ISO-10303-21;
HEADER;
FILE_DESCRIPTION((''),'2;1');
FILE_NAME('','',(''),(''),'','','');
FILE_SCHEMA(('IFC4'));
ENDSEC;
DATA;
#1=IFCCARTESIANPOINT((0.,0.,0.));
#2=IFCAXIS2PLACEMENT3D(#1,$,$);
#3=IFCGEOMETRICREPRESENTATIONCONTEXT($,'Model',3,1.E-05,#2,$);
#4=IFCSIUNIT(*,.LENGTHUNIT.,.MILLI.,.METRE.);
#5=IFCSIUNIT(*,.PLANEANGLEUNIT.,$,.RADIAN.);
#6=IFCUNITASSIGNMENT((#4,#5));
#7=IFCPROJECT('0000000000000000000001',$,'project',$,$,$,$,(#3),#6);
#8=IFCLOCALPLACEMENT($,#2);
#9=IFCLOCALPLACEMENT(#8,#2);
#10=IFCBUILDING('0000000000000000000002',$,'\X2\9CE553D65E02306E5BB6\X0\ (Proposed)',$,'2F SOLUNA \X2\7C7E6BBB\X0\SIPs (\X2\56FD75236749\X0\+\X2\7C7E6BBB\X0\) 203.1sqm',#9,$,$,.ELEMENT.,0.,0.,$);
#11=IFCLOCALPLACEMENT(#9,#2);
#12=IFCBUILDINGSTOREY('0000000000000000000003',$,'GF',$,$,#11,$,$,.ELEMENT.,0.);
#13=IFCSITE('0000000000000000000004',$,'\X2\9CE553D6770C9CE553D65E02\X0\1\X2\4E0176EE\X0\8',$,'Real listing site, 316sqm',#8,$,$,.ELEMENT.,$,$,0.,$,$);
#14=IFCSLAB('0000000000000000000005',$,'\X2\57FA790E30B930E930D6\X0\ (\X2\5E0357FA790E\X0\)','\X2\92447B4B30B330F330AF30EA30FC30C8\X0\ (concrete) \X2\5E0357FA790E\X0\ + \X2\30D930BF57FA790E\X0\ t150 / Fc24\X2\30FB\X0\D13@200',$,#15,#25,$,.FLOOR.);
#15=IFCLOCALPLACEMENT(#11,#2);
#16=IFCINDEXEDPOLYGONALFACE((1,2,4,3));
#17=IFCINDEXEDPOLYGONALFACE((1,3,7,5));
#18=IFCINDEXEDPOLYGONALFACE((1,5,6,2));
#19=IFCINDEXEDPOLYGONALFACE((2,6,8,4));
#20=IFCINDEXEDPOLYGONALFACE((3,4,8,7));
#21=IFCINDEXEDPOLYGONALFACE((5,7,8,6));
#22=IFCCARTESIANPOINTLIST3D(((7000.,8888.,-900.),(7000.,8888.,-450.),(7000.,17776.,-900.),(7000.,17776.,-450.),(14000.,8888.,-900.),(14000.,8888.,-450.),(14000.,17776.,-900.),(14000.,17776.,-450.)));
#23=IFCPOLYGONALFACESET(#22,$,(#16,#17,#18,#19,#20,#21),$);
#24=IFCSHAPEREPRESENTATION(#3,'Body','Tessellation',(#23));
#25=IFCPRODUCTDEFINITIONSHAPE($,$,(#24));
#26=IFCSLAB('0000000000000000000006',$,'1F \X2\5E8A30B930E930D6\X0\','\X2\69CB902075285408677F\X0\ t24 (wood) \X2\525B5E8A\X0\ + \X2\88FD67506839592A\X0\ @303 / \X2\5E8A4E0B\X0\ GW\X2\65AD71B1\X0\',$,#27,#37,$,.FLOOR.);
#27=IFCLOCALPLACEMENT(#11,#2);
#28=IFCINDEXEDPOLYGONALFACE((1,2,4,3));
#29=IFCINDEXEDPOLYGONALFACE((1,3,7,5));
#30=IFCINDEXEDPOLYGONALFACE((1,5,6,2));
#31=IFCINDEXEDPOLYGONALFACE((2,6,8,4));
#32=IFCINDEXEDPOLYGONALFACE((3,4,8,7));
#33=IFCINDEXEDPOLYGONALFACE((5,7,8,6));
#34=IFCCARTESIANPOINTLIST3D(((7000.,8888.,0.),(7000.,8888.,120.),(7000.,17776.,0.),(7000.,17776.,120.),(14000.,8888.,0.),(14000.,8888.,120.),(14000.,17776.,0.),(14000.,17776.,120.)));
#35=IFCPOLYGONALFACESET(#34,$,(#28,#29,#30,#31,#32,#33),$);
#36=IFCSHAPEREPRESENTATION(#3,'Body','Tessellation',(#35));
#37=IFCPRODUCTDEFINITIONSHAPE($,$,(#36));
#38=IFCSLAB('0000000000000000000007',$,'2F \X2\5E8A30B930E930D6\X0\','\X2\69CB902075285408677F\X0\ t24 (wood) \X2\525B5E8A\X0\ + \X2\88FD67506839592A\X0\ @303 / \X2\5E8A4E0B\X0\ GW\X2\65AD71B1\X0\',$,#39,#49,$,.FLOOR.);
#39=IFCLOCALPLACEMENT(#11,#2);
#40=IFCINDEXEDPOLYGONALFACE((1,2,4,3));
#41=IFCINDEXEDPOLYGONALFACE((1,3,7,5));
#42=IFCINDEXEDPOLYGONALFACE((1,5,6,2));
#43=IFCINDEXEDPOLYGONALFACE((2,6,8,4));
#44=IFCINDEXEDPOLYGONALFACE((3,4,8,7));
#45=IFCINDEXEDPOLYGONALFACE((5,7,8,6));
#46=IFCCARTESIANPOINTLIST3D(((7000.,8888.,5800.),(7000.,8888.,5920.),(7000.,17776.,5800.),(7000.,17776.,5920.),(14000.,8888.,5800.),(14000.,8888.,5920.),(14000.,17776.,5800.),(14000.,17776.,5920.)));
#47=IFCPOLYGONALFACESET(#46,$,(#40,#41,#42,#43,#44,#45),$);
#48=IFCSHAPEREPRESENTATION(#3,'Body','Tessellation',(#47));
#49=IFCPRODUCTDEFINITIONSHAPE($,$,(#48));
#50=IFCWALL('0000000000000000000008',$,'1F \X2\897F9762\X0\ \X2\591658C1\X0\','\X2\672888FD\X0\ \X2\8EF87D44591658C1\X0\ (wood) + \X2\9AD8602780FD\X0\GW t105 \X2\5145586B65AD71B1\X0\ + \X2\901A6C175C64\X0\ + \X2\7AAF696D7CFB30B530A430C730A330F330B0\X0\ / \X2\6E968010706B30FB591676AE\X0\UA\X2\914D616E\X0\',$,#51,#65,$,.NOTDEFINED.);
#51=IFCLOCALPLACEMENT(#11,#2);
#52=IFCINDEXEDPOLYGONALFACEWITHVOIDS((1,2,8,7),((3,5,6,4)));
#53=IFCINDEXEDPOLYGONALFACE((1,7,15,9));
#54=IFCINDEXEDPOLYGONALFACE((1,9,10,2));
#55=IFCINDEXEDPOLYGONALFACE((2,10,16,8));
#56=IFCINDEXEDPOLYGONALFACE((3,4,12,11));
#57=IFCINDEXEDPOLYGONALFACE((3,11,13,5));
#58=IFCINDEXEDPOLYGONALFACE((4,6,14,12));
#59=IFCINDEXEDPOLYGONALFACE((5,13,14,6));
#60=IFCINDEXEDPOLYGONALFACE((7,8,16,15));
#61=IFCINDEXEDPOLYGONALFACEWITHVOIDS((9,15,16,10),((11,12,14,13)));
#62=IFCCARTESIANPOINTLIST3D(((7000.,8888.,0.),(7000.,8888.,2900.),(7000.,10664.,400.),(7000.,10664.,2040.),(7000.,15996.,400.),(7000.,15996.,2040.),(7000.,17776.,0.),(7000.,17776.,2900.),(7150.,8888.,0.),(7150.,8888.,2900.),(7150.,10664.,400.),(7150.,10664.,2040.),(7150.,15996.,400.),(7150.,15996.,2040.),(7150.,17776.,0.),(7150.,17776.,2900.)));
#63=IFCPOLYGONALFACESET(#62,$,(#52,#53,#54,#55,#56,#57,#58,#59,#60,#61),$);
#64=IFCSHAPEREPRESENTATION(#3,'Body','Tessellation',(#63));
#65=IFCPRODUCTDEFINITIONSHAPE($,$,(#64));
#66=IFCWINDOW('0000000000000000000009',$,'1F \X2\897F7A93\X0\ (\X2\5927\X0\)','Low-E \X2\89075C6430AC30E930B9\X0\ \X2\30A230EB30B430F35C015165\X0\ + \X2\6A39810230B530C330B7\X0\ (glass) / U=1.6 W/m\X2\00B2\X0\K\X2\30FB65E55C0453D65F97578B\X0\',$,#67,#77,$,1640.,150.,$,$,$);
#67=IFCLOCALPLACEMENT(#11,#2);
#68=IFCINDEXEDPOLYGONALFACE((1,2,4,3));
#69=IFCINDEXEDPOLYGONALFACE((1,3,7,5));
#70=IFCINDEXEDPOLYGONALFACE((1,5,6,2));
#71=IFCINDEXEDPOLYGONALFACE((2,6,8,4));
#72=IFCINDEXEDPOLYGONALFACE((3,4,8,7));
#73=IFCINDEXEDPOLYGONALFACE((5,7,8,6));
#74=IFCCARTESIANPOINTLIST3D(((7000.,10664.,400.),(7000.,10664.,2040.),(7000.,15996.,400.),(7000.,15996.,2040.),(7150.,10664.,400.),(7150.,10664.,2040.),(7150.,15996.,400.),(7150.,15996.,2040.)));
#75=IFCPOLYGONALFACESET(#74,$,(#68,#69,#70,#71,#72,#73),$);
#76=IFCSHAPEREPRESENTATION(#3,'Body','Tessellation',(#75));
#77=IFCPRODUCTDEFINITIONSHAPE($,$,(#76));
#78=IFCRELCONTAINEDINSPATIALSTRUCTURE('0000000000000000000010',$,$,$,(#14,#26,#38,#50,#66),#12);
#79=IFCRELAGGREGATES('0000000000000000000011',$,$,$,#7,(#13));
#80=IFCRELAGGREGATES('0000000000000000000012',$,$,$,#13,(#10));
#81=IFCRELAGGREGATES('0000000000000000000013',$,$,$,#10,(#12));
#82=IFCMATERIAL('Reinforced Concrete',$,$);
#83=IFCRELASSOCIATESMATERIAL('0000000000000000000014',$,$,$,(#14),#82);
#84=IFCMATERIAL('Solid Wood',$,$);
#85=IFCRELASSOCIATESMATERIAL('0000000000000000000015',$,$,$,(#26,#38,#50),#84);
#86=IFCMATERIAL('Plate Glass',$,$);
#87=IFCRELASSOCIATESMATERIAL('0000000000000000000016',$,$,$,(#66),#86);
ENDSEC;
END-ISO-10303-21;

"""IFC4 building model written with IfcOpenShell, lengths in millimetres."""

from ifc_helpers import new_model, si_unit, frame, frame_2d, origin, place, context, project, spatial, rectangle, extrude, material, element, fill, save


model = new_model("IFC4")

# Units and contexts
model_context = context("Model", 3, precision=1e-05, world=origin())
ifc_project = project(units=[si_unit("LENGTHUNIT", "METRE", prefix="MILLI"), si_unit("PLANEANGLEUNIT", "RADIAN")], contexts=[model_context])

# Site, building, storey
site_placement = place(None, origin())
site = spatial("IfcSite", under=ifc_project, at=site_placement, Name="鳥取県鳥取市1丁目8", ObjectType="Real listing site, 316sqm", CompositionType="ELEMENT", RefElevation=0.0)
building_placement = place(site_placement, origin())
building = spatial("IfcBuilding", under=site, at=building_placement, Name="鳥取市の家 (Proposed)", ObjectType="2F SOLUNA 籾殻SIPs (国産杉+籾殻) 203.1sqm", CompositionType="ELEMENT", ElevationOfRefHeight=0.0, ElevationOfTerrain=0.0)
storey_placement = place(building_placement, origin())
storey = spatial("IfcBuildingStorey", under=building, at=storey_placement, Name="GF", CompositionType="ELEMENT", Elevation=0.0)

# Slabs
ifc_material_1 = material(Name="Reinforced Concrete")
slab_1_placement = place(storey_placement, frame((3500.0, 4444.0, -450.0)))
element("IfcSlab", 1, at=slab_1_placement, inside=storey, material=ifc_material_1, Name="基礎スラブ (布基礎)", Description="鉄筋コンクリート (concrete) 布基礎 + ベタ基礎 t150 / Fc24・D13@200", PredefinedType="FLOOR", context=model_context, shape_type="SweptSolid", body=[
    extrude(rectangle(XDim=7000.0, YDim=8888.0, at=frame_2d((3500.0, 4444.0))), frame((3500.0, 4444.0, -450.0)), (0.0, 0.0, 1.0), 450.0),
])
ifc_material_2 = material(Name="Solid Wood")
slab_2_placement = place(storey_placement, frame((3500.0, 4444.0, 0.0)))
element("IfcSlab", 2, at=slab_2_placement, inside=storey, material=ifc_material_2, Name="1F 床スラブ", Description="構造用合板 t24 (wood) 剛床 + 製材根太 @303 / 床下 GW断熱", PredefinedType="FLOOR", context=model_context, shape_type="SweptSolid", body=[
    extrude(rectangle(XDim=7000.0, YDim=8888.0, at=frame_2d((3500.0, 4444.0))), frame((3500.0, 4444.0, 0.0)), (0.0, 0.0, 1.0), 120.0),
])
slab_3_placement = place(storey_placement, frame((3500.0, 4444.0, 2900.0)))
element("IfcSlab", 3, at=slab_3_placement, inside=storey, material=ifc_material_2, Name="2F 床スラブ", Description="構造用合板 t24 (wood) 剛床 + 製材根太 @303 / 床下 GW断熱", PredefinedType="FLOOR", context=model_context, shape_type="SweptSolid", body=[
    extrude(rectangle(XDim=7000.0, YDim=8888.0, at=frame_2d((3500.0, 4444.0))), frame((3500.0, 4444.0, 2900.0)), (0.0, 0.0, 1.0), 120.0),
])

# Shared definitions
ifc_material_3 = material(Name="Plate Glass")

# Wall, opening, window
wall_1_placement = place(storey_placement, frame((3500.0, 4444.0, 0.0)))
wall_1 = element("IfcWall", 4, at=wall_1_placement, inside=storey, material=ifc_material_2, Name="1F 西面 外壁", Description="木製 軸組外壁 (wood) + 高性能GW t105 充填断熱 + 通気層 + 窯業系サイディング / 準耐火・外皮UA配慮", PredefinedType="NOTDEFINED", context=model_context, shape_type="SweptSolid", body=[
    extrude(rectangle(XDim=150.0, YDim=8888.0, at=frame_2d((75.0, 4444.0))), frame((3500.0, 4444.0, 0.0)), (0.0, 0.0, 1.0), 2900.0),
])
opening_1_placement = place(storey_placement, frame((3500.0, 5332.0, 200.0)))
opening_1 = element("IfcOpeningElement", 5, at=opening_1_placement, cuts=wall_1, PredefinedType="NOTDEFINED", context=model_context, shape_type="SweptSolid", body=[
    extrude(rectangle(XDim=150.0, YDim=5332.0, at=frame_2d((75.0, 2666.0))), frame((3500.0, 5332.0, 200.0)), (0.0, 0.0, 1.0), 1640.0),
])
window_1_placement = place(storey_placement, frame((3500.0, 5332.0, 200.0)))
window_1 = element("IfcWindow", 6, at=window_1_placement, inside=storey, material=ifc_material_3, Name="1F 西窓 (大)", Description="Low-E 複層ガラス アルゴン封入 + 樹脂サッシ (glass) / U=1.6 W/m²K・日射取得型", OverallHeight=1640.0, OverallWidth=150.0, context=model_context, shape_type="SweptSolid", body=[
    extrude(rectangle(XDim=150.0, YDim=5332.0, at=frame_2d((75.0, 2666.0))), frame((3500.0, 5332.0, 200.0)), (0.0, 0.0, 1.0), 1640.0),
])
fill(opening_1, window_1)

save(model, "model.ifc")
